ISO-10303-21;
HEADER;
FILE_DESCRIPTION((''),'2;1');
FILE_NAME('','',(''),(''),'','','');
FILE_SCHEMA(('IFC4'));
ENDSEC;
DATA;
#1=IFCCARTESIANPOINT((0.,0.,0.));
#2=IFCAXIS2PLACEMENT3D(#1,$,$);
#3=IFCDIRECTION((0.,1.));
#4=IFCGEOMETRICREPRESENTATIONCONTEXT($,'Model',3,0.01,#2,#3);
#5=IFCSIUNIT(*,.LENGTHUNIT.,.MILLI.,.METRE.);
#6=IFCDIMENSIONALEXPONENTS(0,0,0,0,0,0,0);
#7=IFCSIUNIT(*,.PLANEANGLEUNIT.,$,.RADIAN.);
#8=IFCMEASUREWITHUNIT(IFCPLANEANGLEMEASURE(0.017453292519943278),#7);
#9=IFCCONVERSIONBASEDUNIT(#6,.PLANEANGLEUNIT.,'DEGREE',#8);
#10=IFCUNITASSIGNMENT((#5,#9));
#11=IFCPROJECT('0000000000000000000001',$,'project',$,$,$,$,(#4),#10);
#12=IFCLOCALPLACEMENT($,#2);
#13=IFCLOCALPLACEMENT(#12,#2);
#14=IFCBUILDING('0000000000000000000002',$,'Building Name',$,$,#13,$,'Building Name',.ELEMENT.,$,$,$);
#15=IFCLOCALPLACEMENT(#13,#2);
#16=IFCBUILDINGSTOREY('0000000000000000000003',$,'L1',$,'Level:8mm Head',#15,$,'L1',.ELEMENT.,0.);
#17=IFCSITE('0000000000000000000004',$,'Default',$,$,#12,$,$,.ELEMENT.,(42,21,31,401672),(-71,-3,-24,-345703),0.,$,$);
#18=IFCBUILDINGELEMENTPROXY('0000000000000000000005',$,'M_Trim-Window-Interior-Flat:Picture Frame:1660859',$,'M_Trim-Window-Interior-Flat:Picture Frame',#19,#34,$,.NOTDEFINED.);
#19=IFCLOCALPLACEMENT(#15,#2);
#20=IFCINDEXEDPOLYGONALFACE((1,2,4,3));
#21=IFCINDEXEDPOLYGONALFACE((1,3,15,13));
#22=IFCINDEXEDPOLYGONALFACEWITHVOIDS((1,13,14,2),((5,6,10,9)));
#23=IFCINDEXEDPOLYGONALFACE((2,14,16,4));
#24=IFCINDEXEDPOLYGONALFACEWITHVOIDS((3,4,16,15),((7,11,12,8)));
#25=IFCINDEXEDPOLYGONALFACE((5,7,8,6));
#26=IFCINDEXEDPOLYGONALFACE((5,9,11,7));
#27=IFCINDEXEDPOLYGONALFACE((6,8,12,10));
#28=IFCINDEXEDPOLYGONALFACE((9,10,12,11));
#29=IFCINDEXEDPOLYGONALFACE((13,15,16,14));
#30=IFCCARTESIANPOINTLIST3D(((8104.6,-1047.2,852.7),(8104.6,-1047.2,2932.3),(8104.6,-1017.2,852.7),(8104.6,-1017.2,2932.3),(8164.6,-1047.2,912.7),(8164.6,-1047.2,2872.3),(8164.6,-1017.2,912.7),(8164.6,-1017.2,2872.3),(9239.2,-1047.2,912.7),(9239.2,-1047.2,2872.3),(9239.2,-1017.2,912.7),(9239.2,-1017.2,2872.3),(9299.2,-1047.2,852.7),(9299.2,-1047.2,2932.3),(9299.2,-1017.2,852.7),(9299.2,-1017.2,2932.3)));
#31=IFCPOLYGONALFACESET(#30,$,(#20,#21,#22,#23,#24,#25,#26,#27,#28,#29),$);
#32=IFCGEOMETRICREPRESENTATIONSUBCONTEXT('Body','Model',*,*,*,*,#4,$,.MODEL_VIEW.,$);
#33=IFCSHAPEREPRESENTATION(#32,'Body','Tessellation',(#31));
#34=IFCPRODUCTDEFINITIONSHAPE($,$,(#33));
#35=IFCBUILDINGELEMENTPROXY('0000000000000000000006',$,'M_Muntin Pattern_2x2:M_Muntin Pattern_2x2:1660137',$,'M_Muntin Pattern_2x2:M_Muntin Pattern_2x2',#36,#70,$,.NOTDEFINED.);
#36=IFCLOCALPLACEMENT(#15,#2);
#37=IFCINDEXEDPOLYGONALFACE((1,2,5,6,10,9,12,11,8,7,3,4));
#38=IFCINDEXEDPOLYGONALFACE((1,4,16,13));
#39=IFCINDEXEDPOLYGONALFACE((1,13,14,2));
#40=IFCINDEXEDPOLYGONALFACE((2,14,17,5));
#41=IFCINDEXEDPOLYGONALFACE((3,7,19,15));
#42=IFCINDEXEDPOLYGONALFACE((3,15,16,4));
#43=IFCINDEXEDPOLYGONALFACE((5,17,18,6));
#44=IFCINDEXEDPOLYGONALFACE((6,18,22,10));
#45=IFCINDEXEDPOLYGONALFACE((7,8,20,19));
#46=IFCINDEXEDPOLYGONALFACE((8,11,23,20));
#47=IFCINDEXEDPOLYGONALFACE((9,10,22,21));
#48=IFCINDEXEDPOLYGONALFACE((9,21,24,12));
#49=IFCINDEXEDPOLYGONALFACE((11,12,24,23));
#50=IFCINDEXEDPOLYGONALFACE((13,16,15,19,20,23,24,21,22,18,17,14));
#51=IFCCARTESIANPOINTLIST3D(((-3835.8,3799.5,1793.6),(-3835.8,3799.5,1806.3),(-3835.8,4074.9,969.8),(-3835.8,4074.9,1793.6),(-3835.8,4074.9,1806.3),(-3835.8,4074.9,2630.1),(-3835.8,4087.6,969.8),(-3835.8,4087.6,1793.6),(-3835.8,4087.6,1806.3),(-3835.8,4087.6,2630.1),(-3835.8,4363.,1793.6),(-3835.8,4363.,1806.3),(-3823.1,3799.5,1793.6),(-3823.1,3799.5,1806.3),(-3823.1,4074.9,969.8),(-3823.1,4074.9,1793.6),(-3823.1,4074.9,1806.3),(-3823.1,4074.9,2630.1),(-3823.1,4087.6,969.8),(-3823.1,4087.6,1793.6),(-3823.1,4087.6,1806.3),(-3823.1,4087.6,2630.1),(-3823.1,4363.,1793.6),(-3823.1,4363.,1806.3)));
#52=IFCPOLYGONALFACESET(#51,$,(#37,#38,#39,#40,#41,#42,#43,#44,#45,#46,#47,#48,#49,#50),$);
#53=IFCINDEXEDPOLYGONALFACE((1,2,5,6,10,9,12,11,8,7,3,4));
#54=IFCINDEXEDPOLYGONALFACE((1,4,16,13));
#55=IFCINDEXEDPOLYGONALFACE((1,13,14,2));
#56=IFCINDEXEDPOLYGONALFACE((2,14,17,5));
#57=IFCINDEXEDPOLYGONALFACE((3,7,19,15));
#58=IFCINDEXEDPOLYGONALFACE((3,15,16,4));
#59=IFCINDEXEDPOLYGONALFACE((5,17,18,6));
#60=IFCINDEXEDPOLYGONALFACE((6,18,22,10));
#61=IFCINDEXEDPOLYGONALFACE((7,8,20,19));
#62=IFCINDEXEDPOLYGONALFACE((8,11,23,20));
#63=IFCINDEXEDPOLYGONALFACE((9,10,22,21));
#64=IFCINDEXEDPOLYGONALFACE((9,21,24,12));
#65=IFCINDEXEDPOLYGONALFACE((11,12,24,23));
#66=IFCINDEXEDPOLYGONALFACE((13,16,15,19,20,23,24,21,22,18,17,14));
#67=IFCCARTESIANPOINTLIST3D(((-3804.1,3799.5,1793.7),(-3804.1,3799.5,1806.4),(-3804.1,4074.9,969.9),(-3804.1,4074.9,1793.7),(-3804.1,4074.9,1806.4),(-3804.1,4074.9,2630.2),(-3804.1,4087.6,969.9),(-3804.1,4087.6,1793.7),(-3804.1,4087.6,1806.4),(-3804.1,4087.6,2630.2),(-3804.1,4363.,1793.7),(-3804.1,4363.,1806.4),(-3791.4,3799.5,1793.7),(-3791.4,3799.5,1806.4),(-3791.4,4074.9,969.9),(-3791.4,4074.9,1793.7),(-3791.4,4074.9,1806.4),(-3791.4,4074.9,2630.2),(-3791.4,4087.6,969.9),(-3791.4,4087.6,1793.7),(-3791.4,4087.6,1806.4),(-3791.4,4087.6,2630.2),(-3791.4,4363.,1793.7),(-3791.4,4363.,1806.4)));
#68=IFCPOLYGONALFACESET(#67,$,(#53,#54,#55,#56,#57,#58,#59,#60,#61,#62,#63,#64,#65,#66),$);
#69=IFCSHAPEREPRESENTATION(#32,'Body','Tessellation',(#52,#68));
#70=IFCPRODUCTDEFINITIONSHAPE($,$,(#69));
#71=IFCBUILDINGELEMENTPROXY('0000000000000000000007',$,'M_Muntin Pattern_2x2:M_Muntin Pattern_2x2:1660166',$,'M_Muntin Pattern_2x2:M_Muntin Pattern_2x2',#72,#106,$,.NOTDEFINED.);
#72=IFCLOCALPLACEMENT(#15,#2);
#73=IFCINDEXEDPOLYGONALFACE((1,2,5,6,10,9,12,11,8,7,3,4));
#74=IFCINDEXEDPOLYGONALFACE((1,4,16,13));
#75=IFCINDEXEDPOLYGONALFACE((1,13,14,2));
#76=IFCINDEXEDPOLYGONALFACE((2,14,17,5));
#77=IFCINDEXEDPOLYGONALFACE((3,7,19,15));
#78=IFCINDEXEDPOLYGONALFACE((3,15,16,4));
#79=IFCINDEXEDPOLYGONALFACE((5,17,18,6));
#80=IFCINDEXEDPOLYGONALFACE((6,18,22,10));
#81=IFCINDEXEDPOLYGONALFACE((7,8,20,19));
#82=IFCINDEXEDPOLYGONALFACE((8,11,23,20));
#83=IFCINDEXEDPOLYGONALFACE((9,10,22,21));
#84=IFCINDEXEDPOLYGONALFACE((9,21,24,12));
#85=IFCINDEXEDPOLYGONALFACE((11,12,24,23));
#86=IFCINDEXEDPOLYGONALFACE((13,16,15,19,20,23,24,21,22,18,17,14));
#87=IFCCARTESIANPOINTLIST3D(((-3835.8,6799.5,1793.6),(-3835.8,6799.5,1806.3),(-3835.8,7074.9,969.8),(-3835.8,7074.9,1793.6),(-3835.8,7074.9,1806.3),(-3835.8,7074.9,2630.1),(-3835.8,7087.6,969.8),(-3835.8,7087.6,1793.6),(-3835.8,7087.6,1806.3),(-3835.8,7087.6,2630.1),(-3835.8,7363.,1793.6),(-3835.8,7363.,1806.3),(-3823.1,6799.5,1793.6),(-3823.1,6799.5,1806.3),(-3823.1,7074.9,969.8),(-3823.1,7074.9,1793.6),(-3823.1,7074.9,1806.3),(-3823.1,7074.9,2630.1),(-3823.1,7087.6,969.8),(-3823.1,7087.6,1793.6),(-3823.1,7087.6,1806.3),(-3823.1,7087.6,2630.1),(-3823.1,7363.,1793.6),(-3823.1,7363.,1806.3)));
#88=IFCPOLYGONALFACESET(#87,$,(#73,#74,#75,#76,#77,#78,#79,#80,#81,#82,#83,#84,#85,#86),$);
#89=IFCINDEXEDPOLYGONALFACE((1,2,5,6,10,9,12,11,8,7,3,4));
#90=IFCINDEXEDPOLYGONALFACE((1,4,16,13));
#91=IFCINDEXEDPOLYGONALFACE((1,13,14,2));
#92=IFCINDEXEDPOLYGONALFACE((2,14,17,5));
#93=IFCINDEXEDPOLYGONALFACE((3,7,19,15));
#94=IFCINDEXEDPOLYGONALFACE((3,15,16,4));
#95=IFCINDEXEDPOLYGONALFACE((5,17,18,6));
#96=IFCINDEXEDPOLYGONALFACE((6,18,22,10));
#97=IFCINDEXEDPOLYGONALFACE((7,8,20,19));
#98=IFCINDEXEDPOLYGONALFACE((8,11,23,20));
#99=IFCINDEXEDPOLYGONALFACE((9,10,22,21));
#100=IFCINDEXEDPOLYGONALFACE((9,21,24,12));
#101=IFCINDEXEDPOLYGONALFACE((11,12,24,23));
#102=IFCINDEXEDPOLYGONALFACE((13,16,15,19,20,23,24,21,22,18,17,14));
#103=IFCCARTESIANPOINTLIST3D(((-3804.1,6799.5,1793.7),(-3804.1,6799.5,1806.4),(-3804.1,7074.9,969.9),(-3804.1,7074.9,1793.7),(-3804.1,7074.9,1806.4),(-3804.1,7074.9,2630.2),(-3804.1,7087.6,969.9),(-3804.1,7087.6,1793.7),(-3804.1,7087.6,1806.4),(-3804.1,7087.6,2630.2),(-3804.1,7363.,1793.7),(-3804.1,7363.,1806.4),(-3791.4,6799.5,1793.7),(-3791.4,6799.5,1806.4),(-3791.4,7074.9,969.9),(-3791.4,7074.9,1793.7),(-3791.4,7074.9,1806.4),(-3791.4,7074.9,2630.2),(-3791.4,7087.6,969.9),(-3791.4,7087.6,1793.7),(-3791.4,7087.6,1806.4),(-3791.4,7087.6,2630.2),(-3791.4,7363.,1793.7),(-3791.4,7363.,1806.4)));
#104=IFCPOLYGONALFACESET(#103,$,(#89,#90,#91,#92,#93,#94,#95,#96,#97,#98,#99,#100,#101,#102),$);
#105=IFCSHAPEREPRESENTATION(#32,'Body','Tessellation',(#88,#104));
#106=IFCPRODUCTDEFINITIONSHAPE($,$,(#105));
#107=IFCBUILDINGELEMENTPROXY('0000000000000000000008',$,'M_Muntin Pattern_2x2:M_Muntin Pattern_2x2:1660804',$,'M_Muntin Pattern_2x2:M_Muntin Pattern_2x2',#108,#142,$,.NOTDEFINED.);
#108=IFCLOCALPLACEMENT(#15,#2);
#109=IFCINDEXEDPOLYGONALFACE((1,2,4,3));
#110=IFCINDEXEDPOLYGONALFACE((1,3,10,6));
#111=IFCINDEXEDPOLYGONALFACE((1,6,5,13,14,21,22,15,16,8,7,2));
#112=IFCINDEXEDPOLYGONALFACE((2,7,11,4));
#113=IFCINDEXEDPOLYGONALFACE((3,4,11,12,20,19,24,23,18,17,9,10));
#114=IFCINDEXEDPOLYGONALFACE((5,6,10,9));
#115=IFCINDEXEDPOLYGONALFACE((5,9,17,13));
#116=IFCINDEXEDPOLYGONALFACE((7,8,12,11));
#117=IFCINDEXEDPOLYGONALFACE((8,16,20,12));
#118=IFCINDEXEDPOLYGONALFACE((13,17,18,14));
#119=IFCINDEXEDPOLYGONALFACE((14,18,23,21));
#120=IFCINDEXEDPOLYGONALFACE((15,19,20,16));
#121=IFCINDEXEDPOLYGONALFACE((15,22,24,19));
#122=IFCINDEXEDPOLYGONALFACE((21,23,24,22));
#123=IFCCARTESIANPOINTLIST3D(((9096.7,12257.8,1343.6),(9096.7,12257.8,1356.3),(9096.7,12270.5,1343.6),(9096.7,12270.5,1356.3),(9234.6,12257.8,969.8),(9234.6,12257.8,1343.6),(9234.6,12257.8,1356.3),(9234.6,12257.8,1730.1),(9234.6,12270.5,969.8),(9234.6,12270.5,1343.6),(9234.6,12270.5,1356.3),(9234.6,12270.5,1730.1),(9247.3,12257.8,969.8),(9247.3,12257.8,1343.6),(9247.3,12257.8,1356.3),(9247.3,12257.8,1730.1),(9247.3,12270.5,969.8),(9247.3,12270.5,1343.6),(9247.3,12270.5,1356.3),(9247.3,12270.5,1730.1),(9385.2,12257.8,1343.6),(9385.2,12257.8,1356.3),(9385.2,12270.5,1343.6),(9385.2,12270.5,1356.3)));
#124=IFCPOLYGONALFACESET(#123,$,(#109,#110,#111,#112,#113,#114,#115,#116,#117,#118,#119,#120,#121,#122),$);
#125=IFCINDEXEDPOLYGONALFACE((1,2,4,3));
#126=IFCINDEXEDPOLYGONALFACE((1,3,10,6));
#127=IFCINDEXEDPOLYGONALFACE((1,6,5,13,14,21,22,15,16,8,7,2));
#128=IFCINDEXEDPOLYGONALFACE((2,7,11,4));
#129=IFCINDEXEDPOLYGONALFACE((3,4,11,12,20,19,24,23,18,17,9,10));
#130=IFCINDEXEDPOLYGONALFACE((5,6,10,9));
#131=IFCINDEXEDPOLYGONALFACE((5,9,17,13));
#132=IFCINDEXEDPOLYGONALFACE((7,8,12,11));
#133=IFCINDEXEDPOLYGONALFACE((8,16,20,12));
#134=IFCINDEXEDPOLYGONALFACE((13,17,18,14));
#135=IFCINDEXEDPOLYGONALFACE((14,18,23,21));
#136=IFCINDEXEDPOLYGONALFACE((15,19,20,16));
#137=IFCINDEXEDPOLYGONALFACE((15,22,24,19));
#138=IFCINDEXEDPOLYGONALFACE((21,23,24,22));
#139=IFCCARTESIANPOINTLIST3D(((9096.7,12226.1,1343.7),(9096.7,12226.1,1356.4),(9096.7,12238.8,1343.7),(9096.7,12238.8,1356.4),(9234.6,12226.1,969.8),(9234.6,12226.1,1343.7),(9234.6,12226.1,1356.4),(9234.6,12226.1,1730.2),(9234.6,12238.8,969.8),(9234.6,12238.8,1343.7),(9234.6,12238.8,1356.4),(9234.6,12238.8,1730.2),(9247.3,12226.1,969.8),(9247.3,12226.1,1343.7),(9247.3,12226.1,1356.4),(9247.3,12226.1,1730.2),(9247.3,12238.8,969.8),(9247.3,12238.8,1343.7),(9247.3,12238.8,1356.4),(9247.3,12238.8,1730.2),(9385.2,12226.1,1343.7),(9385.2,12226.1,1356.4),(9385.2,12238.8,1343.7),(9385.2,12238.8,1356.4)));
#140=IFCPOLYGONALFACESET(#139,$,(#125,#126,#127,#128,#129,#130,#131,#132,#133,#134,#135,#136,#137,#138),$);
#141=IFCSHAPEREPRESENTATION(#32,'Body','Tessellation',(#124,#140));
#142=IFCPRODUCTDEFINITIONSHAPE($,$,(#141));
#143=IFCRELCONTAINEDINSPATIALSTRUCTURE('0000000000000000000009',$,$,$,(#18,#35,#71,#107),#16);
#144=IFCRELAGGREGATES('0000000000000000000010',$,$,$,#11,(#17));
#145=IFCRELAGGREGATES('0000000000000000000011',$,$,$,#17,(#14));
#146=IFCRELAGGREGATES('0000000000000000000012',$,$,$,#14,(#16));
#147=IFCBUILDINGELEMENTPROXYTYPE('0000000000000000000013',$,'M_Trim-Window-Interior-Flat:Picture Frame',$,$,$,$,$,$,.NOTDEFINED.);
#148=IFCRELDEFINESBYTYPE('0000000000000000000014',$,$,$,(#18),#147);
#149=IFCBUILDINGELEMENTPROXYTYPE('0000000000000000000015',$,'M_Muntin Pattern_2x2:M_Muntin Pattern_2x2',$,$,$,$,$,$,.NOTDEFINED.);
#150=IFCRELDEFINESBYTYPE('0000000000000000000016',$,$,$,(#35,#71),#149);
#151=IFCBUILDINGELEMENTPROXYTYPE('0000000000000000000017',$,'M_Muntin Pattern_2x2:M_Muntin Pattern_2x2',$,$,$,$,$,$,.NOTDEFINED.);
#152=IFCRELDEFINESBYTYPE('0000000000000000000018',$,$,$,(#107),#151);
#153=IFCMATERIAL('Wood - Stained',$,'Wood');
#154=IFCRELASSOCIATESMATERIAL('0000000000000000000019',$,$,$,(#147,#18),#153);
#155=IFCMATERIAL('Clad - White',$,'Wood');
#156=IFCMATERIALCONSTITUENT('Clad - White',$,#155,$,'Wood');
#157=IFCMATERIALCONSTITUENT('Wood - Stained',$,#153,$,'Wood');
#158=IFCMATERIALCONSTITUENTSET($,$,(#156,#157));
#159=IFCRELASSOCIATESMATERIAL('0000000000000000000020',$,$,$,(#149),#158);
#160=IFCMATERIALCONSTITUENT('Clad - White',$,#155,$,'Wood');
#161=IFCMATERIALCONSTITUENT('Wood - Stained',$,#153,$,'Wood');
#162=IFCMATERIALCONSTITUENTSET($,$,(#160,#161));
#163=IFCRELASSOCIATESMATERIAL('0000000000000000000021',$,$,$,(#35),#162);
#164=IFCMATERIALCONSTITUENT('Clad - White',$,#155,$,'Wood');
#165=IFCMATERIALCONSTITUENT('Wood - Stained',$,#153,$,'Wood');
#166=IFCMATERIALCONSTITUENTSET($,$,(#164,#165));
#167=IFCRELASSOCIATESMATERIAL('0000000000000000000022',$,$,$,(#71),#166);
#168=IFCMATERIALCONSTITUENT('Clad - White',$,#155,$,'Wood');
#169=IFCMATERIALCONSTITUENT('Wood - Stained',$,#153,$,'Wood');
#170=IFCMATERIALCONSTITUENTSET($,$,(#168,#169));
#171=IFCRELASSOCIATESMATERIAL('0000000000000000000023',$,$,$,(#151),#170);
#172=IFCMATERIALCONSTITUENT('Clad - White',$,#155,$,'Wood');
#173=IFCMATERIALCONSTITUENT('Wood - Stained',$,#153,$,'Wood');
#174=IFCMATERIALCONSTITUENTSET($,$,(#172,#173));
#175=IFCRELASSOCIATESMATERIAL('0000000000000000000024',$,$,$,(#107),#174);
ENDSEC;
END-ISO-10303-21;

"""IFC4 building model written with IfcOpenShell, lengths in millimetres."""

from ifc_helpers import new_model, entity, si_unit, converted_unit, direction, frame, origin, place, context, subcontext, project, spatial, indexed_curve, outline, extrude, source, transform, mapped, material, constituent, constituent_set, type_object, type_shapes, element, save


model = new_model("IFC4")

# Units and contexts
model_context = context("Model", 3, precision=0.01, world=origin(), true_north=direction((0.0, 1.0)))
body_context = subcontext(model_context, "Body", "Model", "MODEL_VIEW")
ifc_project = project(units=[si_unit("LENGTHUNIT", "METRE", prefix="MILLI"), converted_unit("PLANEANGLEUNIT", "DEGREE", entity("IfcPlaneAngleMeasure", 0.017453292519943278), si_unit("PLANEANGLEUNIT", "RADIAN"), dimensions=[0, 0, 0, 0, 0, 0, 0])], contexts=[model_context])

# Site, building, storey
site_placement = place(None, origin())
site = spatial("IfcSite", under=ifc_project, at=site_placement, Name="Default", CompositionType="ELEMENT", RefLatitude=(42, 21, 31, 401672), RefLongitude=(-71, -3, -24, -345703), RefElevation=0.0)
building_placement = place(site_placement, origin())
building = spatial("IfcBuilding", under=site, at=building_placement, Name="Building Name", LongName="Building Name", CompositionType="ELEMENT")
storey_placement = place(building_placement, origin())
storey = spatial("IfcBuildingStorey", under=building, at=storey_placement, Name="L1", ObjectType="Level:8mm Head", LongName="L1", CompositionType="ELEMENT", Elevation=0.0)

# Building element proxies
ifc_material_1 = material(Name="Clad - White", Category="Wood")
ifc_material_2 = material(Name="Wood - Stained", Category="Wood")
building_element_proxy_type_1 = type_object("IfcBuildingElementProxyType", Name="M_Trim-Window-Interior-Flat:Picture Frame", PredefinedType="NOTDEFINED", material=ifc_material_2)
shared_shape_1 = source(origin(), body_context, "Body", "SweptSolid", [
    extrude(outline(indexed_curve([(-597.3, -1039.8), (597.3, -1039.8), (597.3, 1039.8), (-597.3, 1039.8), (-597.3, -1039.8)], self_intersect=False), holes=[indexed_curve([(-537.3, -979.8), (-537.3, 979.8), (537.3, 979.8), (537.3, -979.8), (-537.3, -979.8)], self_intersect=False)]), frame((0.0, -992.5, 0.0), z_axis=(0.0, 0.0, 1.0), x_axis=(-1.0, 0.0, 0.0)), (0.0, 0.0, 1.0), 30.0),
])
type_shapes(building_element_proxy_type_1, [shared_shape_1])
for number, where, z_axis, x_axis, name in (
    (1, (8701.9, -1017.2, 2885.0), (0.0, -1.0, 0.0), (1.0, 0.0, 0.0), "M_Trim-Window-Interior-Flat:Picture Frame:1660859"),
):
    element("IfcBuildingElementProxy", number, at=place(storey_placement, frame(where, z_axis=z_axis, x_axis=x_axis)), inside=storey, type_object=building_element_proxy_type_1, material=ifc_material_2, Name=name, ObjectType="M_Trim-Window-Interior-Flat:Picture Frame", PredefinedType="NOTDEFINED", context=body_context, shape_type="MappedRepresentation", body=[
        mapped(shared_shape_1, transform((0.0, 0.0, 0.0), scale=1.0)),
    ])
ifc_constituent_1 = constituent(ifc_material_1, Name="Clad - White", Category="Wood")
ifc_constituent_2 = constituent(ifc_material_2, Name="Wood - Stained", Category="Wood")
ifc_constituent_set_1 = constituent_set(constituents=[ifc_constituent_1, ifc_constituent_2])
ifc_constituent_3 = constituent(ifc_material_1, Name="Clad - White", Category="Wood")
ifc_constituent_4 = constituent(ifc_material_2, Name="Wood - Stained", Category="Wood")
ifc_constituent_set_2 = constituent_set(constituents=[ifc_constituent_3, ifc_constituent_4])
building_element_proxy_type_2 = type_object("IfcBuildingElementProxyType", Name="M_Muntin Pattern_2x2:M_Muntin Pattern_2x2", PredefinedType="NOTDEFINED", material=ifc_constituent_set_2)
shared_shape_2 = source(origin(), body_context, "Body", "SweptSolid", [
    extrude(outline(indexed_curve([(6.4, -6.4), (830.1, -6.4), (830.1, 6.3), (6.4, 6.3), (6.4, 281.7), (-6.3, 281.7), (-6.3, 6.3), (-830.2, 6.3), (-830.2, -6.4), (-6.3, -6.4), (-6.3, -281.7), (6.4, -281.7), (6.4, -6.4)], self_intersect=False)), frame((0.0, -22.2, 830.1), z_axis=(0.0, 1.0, 0.0), x_axis=(0.0, 0.0, 1.0)), (0.0, 0.0, 1.0), 12.7),
    extrude(outline(indexed_curve([(6.4, -6.4), (830.2, -6.4), (830.2, 6.3), (6.4, 6.3), (6.4, 281.7), (-6.3, 281.7), (-6.3, 6.3), (-830.2, 6.3), (-830.2, -6.4), (-6.3, -6.4), (-6.3, -281.7), (6.4, -281.7), (6.4, -6.4)], self_intersect=False)), frame((0.0, 9.5, 830.2), z_axis=(0.0, 1.0, 0.0), x_axis=(0.0, 0.0, 1.0)), (0.0, 0.0, 1.0), 12.7),
])
type_shapes(building_element_proxy_type_2, [shared_shape_2])
proxy_1_placement = place(storey_placement, frame((-3813.6, 4081.2, 969.9), z_axis=(0.0, 0.0, 1.0), x_axis=(0.0, -1.0, 0.0)))
element("IfcBuildingElementProxy", 2, at=proxy_1_placement, inside=storey, type_object=building_element_proxy_type_2, material=ifc_constituent_set_1, Name="M_Muntin Pattern_2x2:M_Muntin Pattern_2x2:1660137", ObjectType="M_Muntin Pattern_2x2:M_Muntin Pattern_2x2", PredefinedType="NOTDEFINED", context=body_context, shape_type="MappedRepresentation", body=[
    mapped(shared_shape_2, transform((0.0, 0.0, 0.0), scale=1.0)),
])
ifc_constituent_5 = constituent(ifc_material_1, Name="Clad - White", Category="Wood")
ifc_constituent_6 = constituent(ifc_material_2, Name="Wood - Stained", Category="Wood")
ifc_constituent_set_3 = constituent_set(constituents=[ifc_constituent_5, ifc_constituent_6])
proxy_2_placement = place(storey_placement, frame((-3813.6, 7081.2, 969.9), z_axis=(0.0, 0.0, 1.0), x_axis=(0.0, -1.0, 0.0)))
element("IfcBuildingElementProxy", 3, at=proxy_2_placement, inside=storey, type_object=building_element_proxy_type_2, material=ifc_constituent_set_3, Name="M_Muntin Pattern_2x2:M_Muntin Pattern_2x2:1660166", ObjectType="M_Muntin Pattern_2x2:M_Muntin Pattern_2x2", PredefinedType="NOTDEFINED", context=body_context, shape_type="MappedRepresentation", body=[
    mapped(shared_shape_2, transform((0.0, 0.0, 0.0), scale=1.0)),
])
ifc_constituent_7 = constituent(ifc_material_1, Name="Clad - White", Category="Wood")
ifc_constituent_8 = constituent(ifc_material_2, Name="Wood - Stained", Category="Wood")
ifc_constituent_set_4 = constituent_set(constituents=[ifc_constituent_7, ifc_constituent_8])
ifc_constituent_9 = constituent(ifc_material_1, Name="Clad - White", Category="Wood")
ifc_constituent_10 = constituent(ifc_material_2, Name="Wood - Stained", Category="Wood")
ifc_constituent_set_5 = constituent_set(constituents=[ifc_constituent_9, ifc_constituent_10])
building_element_proxy_type_3 = type_object("IfcBuildingElementProxyType", Name="M_Muntin Pattern_2x2:M_Muntin Pattern_2x2", PredefinedType="NOTDEFINED", material=ifc_constituent_set_5)
shared_shape_3 = source(origin(), body_context, "Body", "SweptSolid", [
    extrude(outline(indexed_curve([(6.4, -6.4), (380.1, -6.4), (380.1, 6.3), (6.4, 6.3), (6.4, 144.2), (-6.3, 144.2), (-6.3, 6.3), (-380.2, 6.3), (-380.2, -6.4), (-6.3, -6.4), (-6.3, -144.2), (6.4, -144.2), (6.4, -6.4)], self_intersect=False)), frame((0.0, 9.5, 380.1), z_axis=(0.0, 1.0, 0.0), x_axis=(0.0, 0.0, 1.0)), (0.0, 0.0, 1.0), 12.7),
    extrude(outline(indexed_curve([(6.4, -6.4), (380.2, -6.4), (380.2, 6.3), (6.4, 6.3), (6.4, 144.2), (-6.3, 144.2), (-6.3, 6.3), (-380.2, 6.3), (-380.2, -6.4), (-6.3, -6.4), (-6.3, -144.2), (6.4, -144.2), (6.4, -6.4)], self_intersect=False)), frame((0.0, -22.2, 380.2), z_axis=(0.0, 1.0, 0.0), x_axis=(0.0, 0.0, 1.0)), (0.0, 0.0, 1.0), 12.7),
])
type_shapes(building_element_proxy_type_3, [shared_shape_3])
proxy_3_placement = place(storey_placement, frame((9241.0, 12248.3, 969.8)))
element("IfcBuildingElementProxy", 4, at=proxy_3_placement, inside=storey, type_object=building_element_proxy_type_3, material=ifc_constituent_set_4, Name="M_Muntin Pattern_2x2:M_Muntin Pattern_2x2:1660804", ObjectType="M_Muntin Pattern_2x2:M_Muntin Pattern_2x2", PredefinedType="NOTDEFINED", context=body_context, shape_type="MappedRepresentation", body=[
    mapped(shared_shape_3, transform((0.0, 0.0, 0.0), scale=1.0)),
])

save(model, "model.ifc")
